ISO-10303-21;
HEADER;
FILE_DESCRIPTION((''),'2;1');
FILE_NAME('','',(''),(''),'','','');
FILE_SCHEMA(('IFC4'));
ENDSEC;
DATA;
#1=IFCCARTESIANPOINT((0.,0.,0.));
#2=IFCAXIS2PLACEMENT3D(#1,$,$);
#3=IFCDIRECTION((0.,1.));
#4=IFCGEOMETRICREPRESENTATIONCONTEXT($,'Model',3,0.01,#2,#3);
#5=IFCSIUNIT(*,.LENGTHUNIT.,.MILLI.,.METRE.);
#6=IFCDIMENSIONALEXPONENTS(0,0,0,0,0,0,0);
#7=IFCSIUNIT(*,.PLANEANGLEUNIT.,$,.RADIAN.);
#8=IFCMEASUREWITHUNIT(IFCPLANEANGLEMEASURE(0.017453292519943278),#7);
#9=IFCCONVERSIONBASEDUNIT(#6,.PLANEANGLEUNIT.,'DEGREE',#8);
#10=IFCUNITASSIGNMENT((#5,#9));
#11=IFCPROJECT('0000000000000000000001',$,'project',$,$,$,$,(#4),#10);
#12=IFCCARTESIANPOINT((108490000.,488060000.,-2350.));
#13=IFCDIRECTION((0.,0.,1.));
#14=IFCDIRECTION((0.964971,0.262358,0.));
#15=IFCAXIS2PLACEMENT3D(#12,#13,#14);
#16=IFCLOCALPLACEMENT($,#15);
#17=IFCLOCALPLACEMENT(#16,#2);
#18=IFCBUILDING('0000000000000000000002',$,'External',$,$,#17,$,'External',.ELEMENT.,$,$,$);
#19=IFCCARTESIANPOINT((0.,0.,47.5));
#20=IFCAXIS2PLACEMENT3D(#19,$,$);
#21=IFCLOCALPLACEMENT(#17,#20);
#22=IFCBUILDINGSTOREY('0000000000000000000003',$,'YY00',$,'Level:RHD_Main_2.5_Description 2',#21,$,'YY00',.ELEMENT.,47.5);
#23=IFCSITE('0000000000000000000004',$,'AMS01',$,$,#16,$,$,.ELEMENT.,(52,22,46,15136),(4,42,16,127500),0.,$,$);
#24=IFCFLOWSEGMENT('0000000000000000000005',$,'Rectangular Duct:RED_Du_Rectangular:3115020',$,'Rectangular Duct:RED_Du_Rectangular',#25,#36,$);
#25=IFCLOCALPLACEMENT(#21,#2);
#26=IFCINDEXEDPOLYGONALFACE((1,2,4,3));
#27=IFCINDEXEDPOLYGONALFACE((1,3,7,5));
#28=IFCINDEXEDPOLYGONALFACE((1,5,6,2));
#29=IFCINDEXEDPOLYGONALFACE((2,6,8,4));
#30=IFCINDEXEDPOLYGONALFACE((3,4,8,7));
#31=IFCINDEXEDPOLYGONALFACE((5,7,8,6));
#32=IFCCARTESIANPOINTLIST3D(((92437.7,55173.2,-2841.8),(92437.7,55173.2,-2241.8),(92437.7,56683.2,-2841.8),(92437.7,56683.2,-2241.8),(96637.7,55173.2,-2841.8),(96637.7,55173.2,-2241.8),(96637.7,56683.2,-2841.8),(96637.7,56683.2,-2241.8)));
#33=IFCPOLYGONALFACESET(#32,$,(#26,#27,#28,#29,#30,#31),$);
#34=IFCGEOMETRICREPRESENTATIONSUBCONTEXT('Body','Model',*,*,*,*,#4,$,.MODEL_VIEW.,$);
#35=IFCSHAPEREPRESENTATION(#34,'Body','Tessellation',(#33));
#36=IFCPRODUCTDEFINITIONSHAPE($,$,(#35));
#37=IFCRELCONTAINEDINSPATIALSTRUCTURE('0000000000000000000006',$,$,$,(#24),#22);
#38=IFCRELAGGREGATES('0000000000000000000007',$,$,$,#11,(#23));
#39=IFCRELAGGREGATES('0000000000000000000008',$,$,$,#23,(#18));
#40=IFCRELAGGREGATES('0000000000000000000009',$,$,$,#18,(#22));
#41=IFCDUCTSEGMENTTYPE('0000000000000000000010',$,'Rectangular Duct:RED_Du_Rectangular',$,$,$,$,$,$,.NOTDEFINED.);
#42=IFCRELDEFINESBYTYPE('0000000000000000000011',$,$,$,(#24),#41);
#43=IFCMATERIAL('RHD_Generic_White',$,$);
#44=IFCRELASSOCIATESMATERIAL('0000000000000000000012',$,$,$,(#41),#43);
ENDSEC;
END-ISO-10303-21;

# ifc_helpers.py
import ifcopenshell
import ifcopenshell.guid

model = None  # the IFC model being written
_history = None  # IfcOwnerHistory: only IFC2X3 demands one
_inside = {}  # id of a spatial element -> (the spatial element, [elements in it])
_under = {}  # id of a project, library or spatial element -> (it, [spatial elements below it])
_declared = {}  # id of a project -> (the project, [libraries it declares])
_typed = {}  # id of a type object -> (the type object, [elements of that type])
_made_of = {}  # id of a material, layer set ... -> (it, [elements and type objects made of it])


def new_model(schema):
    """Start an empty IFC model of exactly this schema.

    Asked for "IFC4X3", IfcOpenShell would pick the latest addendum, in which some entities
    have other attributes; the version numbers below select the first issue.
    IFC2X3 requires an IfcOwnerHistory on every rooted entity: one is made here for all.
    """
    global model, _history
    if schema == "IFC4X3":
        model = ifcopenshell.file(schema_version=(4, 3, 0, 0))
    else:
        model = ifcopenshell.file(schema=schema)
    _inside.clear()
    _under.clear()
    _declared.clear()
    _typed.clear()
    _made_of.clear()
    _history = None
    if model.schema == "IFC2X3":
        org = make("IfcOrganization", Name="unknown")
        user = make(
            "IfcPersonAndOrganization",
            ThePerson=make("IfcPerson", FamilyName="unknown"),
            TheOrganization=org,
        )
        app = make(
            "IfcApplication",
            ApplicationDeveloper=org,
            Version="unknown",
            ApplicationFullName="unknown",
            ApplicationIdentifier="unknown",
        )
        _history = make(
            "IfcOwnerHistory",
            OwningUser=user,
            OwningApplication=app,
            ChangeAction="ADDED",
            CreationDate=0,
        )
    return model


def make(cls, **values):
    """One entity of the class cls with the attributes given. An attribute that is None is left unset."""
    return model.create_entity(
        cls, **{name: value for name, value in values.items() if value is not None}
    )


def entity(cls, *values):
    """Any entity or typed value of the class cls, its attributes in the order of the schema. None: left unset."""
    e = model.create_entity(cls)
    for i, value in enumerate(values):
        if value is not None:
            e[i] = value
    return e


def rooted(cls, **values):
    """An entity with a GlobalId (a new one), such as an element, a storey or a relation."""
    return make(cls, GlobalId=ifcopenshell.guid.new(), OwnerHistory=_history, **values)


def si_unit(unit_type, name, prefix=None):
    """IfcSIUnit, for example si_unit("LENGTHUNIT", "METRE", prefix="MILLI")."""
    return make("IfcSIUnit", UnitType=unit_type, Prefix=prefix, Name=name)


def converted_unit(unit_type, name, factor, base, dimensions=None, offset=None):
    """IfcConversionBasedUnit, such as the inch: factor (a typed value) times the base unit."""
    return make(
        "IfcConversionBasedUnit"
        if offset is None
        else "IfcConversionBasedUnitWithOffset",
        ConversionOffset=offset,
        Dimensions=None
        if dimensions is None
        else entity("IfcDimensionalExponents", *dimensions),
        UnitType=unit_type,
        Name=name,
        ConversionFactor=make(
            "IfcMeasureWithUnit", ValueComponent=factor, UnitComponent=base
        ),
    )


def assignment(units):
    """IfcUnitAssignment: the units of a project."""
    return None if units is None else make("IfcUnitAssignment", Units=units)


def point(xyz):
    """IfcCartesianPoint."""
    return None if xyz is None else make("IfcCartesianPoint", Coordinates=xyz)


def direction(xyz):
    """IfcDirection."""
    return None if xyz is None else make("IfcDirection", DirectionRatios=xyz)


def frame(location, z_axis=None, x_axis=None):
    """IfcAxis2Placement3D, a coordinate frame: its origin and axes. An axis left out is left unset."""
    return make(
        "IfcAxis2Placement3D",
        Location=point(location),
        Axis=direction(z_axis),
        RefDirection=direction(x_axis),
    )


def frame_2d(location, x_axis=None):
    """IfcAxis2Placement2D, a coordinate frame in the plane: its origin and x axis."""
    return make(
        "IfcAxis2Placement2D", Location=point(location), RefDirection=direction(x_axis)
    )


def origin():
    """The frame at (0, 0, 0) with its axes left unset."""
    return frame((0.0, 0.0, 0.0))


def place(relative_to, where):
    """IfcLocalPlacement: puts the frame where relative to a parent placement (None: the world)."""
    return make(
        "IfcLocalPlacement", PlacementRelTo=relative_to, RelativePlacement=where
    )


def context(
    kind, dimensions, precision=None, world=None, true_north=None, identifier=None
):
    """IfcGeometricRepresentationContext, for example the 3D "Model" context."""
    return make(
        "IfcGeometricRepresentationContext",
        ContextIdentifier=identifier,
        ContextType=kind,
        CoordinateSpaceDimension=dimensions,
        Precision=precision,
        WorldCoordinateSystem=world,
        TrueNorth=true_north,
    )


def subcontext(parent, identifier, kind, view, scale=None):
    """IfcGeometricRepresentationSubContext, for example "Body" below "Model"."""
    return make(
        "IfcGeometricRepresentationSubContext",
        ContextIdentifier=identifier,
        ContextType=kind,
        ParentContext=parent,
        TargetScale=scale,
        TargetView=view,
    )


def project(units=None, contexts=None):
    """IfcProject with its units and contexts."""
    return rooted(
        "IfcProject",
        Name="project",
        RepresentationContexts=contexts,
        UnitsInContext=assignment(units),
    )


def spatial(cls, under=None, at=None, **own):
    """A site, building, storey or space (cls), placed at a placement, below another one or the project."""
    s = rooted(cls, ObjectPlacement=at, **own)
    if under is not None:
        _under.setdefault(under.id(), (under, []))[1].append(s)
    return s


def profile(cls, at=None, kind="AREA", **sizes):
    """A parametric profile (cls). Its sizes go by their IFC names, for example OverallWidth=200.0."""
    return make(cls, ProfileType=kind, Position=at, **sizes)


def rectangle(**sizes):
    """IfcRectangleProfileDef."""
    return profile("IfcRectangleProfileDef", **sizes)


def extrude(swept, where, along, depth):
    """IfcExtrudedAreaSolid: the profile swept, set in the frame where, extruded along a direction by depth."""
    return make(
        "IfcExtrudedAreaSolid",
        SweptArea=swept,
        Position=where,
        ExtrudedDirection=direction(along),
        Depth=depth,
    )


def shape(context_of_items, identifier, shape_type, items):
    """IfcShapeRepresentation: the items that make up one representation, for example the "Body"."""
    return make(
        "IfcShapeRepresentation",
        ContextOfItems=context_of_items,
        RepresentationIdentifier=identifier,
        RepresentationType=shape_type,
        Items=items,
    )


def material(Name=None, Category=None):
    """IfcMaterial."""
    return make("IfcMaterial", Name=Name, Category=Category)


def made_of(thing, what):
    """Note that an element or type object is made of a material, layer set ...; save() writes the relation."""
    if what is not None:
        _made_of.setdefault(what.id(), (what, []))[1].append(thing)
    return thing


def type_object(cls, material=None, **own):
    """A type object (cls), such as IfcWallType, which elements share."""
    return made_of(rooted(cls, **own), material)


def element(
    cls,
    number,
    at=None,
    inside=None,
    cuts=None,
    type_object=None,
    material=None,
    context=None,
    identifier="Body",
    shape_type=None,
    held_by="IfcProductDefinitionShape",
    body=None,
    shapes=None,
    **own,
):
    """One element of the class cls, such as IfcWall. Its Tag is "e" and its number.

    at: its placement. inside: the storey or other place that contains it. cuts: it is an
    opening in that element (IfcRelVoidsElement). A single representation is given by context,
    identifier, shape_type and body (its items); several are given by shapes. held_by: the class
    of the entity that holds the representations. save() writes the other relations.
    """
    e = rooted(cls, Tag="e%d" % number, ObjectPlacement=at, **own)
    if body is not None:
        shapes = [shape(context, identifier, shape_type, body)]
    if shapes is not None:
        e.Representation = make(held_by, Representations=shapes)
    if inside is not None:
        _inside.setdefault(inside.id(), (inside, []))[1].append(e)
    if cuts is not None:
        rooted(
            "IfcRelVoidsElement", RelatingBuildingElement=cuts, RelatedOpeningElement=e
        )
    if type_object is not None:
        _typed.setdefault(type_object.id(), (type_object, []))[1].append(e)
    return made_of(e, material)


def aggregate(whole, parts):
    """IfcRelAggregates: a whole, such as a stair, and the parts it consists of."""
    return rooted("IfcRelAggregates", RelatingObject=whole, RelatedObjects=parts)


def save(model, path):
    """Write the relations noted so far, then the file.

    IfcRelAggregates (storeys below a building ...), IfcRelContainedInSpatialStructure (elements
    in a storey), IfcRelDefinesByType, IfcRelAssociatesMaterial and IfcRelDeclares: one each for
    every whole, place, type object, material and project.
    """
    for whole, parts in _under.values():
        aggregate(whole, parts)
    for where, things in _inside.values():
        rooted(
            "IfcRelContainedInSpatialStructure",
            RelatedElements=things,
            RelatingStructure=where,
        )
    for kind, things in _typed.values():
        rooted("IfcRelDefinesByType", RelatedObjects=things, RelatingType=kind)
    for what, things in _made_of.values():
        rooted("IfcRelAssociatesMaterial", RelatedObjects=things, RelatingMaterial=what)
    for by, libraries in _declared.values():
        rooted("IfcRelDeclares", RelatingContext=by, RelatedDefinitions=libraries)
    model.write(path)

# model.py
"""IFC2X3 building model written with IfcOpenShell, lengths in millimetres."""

from ifc_helpers import new_model, entity, si_unit, converted_unit, direction, frame, frame_2d, origin, place, context, subcontext, project, spatial, rectangle, extrude, material, type_object, element, save


model = new_model("IFC2X3")

# Units and contexts
model_context = context("Model", 3, precision=0.01, world=origin(), true_north=direction((0.0, 1.0)))
body_context = subcontext(model_context, "Body", "Model", "MODEL_VIEW")
ifc_project = project(units=[si_unit("LENGTHUNIT", "METRE", prefix="MILLI"), converted_unit("PLANEANGLEUNIT", "DEGREE", entity("IfcPlaneAngleMeasure", 0.017453292519943278), si_unit("PLANEANGLEUNIT", "RADIAN"), dimensions=[0, 0, 0, 0, 0, 0, 0])], contexts=[model_context])

# Site, building, storey
site_placement = place(None, frame((108490000.0, 488060000.0, -2350.0), z_axis=(0.0, 0.0, 1.0), x_axis=(0.964971, 0.262358, 0.0)))
site = spatial("IfcSite", under=ifc_project, at=site_placement, Name="AMS01", CompositionType="ELEMENT", RefLatitude=(52, 22, 46, 15136), RefLongitude=(4, 42, 16, 127500), RefElevation=0.0)
building_placement = place(site_placement, origin())
building = spatial("IfcBuilding", under=site, at=building_placement, Name="External", LongName="External", CompositionType="ELEMENT")
storey_placement = place(building_placement, frame((0.0, 0.0, 47.5)))
storey = spatial("IfcBuildingStorey", under=building, at=storey_placement, Name="YY00", ObjectType="Level:RHD_Main_2.5_Description 2", LongName="YY00", CompositionType="ELEMENT", Elevation=47.5)

# Flow segment
ifc_material = material(Name="RHD_Generic_White")
duct_segment_type = type_object("IfcDuctSegmentType", Name="Rectangular Duct:RED_Du_Rectangular", PredefinedType="NOTDEFINED", material=ifc_material)
flow_segment_1_placement = place(storey_placement, origin())
element("IfcFlowSegment", 1, at=flow_segment_1_placement, inside=storey, type_object=duct_segment_type, Name="Rectangular Duct:RED_Du_Rectangular:3115020", ObjectType="Rectangular Duct:RED_Du_Rectangular", context=body_context, shape_type="SweptSolid", body=[
    extrude(rectangle(XDim=4200.0, YDim=1510.0, at=frame_2d((0.0, 0.0), x_axis=(1.0, 0.0))), frame((94537.7, 55928.2, -2841.8), z_axis=(0.0, 0.0, 1.0), x_axis=(-1.0, 0.0, 0.0)), (0.0, 0.0, 1.0), 600.0),
])

save(model, "model.ifc")
